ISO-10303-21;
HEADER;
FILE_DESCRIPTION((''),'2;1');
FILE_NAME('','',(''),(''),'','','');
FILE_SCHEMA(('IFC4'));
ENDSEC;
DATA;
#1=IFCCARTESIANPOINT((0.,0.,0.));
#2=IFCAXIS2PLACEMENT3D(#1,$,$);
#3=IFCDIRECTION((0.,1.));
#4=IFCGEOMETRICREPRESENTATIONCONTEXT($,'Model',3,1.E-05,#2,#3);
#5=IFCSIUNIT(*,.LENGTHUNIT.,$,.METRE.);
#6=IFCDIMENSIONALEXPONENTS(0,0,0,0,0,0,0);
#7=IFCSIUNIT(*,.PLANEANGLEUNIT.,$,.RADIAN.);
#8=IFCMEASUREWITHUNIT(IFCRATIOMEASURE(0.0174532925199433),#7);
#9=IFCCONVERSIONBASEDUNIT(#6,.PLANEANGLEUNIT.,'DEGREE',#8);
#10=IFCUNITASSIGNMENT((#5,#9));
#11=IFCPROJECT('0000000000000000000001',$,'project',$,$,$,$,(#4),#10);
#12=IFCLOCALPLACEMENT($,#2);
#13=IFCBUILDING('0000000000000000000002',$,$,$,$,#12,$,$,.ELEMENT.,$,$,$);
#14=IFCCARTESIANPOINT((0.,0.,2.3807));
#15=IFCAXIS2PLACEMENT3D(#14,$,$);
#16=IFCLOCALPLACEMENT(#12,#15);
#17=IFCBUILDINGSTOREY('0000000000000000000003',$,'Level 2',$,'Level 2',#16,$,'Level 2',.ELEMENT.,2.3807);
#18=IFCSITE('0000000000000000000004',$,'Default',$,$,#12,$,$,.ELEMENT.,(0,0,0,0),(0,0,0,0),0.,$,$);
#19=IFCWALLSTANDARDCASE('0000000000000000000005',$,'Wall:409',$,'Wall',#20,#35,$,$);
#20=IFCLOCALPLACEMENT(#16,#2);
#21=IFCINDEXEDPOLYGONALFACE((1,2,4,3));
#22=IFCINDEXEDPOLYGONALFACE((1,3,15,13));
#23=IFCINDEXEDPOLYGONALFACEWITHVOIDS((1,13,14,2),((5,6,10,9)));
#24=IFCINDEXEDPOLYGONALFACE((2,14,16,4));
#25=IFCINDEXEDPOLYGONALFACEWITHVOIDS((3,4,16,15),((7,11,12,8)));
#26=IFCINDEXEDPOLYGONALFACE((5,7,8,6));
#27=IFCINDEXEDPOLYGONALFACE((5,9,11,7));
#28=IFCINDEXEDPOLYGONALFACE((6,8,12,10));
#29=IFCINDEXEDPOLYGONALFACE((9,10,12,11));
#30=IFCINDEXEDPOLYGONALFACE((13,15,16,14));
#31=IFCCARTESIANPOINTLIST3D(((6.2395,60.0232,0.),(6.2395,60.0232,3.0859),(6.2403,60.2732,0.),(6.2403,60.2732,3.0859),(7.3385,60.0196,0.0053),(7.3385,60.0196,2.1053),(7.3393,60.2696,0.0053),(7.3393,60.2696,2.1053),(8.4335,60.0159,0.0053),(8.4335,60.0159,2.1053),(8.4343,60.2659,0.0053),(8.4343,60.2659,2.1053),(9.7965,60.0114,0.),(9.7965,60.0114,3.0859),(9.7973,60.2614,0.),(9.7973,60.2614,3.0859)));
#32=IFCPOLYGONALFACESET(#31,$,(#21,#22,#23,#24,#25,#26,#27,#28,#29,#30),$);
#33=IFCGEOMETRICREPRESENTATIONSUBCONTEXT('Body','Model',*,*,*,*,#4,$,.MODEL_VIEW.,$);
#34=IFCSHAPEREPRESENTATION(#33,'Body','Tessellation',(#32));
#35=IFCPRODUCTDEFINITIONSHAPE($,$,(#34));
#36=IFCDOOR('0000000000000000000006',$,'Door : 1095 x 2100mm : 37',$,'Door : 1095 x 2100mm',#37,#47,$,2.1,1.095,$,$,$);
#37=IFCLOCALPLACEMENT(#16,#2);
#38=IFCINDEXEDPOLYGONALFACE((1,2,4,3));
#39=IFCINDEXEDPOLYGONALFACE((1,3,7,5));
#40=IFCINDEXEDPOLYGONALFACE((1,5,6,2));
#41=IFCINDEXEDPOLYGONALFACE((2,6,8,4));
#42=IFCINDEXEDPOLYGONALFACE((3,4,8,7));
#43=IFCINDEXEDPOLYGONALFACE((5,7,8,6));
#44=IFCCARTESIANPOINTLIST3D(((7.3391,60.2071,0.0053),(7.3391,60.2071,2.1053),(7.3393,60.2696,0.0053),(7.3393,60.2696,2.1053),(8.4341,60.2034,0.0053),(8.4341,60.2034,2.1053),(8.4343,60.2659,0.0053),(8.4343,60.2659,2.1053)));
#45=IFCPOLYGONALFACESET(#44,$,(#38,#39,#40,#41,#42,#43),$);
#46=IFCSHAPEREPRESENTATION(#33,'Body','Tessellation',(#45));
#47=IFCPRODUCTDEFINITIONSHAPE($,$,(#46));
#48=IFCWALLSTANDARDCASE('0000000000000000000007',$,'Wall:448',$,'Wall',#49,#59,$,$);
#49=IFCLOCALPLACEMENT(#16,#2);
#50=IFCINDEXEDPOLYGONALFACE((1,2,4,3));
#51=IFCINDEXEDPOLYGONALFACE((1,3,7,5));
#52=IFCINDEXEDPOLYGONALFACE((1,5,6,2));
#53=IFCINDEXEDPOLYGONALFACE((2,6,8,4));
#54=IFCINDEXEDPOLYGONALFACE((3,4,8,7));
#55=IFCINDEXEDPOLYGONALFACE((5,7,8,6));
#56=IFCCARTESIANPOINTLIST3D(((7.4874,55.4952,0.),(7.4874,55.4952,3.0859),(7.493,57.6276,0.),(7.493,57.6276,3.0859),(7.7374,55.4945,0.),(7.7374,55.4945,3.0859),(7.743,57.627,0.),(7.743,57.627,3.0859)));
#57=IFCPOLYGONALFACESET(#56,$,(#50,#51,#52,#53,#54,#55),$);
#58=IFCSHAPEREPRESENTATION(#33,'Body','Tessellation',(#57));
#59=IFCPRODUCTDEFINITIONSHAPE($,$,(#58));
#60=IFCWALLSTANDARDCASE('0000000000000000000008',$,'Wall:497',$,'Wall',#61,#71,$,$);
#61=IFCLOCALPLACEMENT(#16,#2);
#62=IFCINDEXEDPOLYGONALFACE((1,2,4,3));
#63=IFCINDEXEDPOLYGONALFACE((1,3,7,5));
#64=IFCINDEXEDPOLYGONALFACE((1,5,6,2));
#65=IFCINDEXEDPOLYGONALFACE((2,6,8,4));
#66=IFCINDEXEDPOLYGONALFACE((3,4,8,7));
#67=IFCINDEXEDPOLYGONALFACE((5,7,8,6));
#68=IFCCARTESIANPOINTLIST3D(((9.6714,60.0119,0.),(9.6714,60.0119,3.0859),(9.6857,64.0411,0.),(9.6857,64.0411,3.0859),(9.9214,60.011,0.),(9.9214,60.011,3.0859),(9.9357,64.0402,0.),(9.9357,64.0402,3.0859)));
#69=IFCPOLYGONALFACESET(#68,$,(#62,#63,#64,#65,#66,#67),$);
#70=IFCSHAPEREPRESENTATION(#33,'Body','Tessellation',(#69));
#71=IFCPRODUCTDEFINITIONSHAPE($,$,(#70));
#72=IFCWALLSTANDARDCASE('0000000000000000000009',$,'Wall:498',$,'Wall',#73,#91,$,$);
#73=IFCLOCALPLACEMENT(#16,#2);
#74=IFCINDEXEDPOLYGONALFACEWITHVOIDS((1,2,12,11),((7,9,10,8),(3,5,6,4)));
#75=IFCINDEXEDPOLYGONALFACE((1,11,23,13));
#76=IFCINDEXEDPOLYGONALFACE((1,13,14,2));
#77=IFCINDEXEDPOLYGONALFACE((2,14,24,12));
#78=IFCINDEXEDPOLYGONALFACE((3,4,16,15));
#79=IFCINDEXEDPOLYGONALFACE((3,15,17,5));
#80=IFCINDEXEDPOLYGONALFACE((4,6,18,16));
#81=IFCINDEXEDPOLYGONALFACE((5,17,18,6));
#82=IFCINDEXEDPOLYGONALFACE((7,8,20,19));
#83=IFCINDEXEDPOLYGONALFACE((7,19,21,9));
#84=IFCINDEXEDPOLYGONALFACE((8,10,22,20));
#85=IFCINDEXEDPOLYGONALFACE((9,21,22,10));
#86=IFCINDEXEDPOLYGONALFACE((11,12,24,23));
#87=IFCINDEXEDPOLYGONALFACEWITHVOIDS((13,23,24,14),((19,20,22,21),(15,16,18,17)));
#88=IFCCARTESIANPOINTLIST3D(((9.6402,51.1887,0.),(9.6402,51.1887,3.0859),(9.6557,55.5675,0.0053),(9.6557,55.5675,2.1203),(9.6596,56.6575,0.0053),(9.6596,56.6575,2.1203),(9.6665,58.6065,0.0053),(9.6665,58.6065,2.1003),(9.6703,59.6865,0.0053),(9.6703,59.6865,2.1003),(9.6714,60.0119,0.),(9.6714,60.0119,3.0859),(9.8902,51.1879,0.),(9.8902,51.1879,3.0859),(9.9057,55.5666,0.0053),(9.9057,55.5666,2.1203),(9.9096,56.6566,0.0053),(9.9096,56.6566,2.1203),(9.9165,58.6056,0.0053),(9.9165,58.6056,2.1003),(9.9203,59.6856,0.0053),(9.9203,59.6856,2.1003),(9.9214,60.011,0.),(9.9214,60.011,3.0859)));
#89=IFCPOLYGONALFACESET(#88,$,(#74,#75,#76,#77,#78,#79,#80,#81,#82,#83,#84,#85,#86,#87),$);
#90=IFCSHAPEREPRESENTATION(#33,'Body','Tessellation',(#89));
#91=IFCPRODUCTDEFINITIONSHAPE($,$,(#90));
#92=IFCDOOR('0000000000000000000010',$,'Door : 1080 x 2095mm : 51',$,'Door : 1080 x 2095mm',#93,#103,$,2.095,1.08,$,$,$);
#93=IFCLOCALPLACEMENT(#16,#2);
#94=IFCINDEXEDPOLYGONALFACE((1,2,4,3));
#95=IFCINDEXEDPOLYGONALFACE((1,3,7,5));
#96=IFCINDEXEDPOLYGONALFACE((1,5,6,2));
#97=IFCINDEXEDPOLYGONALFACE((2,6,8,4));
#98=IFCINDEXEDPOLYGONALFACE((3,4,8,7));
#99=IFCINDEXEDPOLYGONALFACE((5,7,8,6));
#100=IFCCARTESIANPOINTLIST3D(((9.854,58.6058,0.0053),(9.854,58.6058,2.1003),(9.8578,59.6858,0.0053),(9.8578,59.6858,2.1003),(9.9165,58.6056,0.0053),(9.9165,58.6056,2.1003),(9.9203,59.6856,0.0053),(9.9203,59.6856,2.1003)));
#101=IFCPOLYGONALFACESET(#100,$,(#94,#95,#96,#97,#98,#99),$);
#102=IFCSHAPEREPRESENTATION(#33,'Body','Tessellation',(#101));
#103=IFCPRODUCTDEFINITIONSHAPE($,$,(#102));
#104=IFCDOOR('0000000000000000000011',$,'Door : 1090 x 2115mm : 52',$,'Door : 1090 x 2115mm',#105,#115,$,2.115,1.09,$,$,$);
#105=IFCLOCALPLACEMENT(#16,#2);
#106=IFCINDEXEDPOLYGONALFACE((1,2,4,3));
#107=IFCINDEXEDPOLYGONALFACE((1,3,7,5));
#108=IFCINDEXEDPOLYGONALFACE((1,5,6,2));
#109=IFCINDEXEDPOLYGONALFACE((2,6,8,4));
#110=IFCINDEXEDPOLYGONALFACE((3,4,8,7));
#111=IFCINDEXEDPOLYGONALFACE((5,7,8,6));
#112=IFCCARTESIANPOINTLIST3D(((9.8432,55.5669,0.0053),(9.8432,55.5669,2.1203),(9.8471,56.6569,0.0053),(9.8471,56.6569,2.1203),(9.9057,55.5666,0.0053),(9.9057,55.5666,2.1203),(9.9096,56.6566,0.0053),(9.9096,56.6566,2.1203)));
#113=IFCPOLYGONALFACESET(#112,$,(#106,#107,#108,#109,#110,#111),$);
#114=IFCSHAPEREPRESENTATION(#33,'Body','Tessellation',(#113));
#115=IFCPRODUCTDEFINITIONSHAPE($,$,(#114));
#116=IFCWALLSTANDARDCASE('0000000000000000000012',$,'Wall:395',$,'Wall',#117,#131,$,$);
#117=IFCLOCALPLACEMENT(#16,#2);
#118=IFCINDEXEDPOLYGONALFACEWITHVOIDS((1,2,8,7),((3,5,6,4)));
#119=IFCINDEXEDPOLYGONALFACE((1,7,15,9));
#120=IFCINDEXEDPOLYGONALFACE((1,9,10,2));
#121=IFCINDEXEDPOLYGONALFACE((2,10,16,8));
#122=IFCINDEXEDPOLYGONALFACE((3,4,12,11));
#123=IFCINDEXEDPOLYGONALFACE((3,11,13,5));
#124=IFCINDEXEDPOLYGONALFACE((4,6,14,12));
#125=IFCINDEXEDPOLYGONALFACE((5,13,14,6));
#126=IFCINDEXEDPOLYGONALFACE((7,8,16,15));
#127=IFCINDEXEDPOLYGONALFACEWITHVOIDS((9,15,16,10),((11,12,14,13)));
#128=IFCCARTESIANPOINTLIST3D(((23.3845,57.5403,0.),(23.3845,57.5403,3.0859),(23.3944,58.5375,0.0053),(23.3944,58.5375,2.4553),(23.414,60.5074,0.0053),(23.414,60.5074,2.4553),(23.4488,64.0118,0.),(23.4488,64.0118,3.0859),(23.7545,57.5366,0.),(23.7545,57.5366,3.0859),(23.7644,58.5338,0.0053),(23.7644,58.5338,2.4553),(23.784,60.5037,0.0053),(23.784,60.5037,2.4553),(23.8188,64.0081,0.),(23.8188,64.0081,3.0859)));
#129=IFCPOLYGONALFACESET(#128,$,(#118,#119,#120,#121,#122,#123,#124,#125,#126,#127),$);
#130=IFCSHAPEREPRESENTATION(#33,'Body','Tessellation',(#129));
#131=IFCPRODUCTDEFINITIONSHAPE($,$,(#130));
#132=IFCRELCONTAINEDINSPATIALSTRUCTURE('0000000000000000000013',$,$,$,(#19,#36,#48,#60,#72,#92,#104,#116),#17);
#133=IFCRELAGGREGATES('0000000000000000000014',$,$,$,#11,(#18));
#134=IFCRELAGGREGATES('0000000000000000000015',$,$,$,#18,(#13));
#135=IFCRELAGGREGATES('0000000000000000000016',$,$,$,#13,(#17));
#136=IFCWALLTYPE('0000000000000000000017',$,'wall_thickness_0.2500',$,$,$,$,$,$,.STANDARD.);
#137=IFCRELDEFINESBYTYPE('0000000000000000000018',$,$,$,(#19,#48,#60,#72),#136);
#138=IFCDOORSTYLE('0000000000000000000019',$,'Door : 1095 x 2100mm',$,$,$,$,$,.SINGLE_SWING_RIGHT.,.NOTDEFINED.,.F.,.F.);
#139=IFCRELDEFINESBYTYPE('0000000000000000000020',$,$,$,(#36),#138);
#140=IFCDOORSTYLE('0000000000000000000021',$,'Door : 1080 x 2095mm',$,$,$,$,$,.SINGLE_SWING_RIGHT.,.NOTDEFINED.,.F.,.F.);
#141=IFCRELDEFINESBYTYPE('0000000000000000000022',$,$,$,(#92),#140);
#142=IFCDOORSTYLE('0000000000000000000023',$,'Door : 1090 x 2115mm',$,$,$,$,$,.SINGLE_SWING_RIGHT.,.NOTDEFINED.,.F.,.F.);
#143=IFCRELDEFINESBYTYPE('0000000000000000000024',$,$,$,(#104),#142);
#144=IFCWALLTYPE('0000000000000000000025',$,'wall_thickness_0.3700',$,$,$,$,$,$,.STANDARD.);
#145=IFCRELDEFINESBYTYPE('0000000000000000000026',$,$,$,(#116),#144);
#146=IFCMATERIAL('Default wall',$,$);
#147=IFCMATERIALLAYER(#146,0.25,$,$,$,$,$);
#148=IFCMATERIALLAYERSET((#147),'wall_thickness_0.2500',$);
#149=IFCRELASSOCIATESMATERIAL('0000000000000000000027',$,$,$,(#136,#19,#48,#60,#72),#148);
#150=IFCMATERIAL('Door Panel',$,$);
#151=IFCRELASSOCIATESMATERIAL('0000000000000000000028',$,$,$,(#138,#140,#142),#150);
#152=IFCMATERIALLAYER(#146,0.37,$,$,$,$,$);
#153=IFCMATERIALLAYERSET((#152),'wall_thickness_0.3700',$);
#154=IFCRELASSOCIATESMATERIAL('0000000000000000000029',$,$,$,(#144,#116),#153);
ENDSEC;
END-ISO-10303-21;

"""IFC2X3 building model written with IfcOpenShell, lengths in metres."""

from ifc_helpers import new_model, entity, si_unit, converted_unit, direction, frame, frame_2d, origin, origin_2d_with_axis, place, context, subcontext, project, spatial, polyline, rectangle, outline, extrude, source, transform, mapped, material, layer, layer_set, layer_usage, type_object, type_shapes, element, fill, save


model = new_model("IFC2X3")

# Units and contexts
model_context = context("Model", 3, precision=1e-05, world=origin(), true_north=direction((0.0, 1.0)))
body_context = subcontext(model_context, "Body", "Model", "MODEL_VIEW")
ifc_project = project(units=[si_unit("LENGTHUNIT", "METRE"), converted_unit("PLANEANGLEUNIT", "DEGREE", entity("IfcRatioMeasure", 0.0174532925199433), si_unit("PLANEANGLEUNIT", "RADIAN"), dimensions=[0, 0, 0, 0, 0, 0, 0])], contexts=[model_context])

# Site, building, storey
placement_1 = place(None, origin())
site = spatial("IfcSite", under=ifc_project, at=placement_1, Name="Default", CompositionType="ELEMENT", RefLatitude=(0, 0, 0, 0), RefLongitude=(0, 0, 0, 0), RefElevation=0.0)
building = spatial("IfcBuilding", under=site, at=placement_1, CompositionType="ELEMENT")
storey_placement = place(placement_1, frame((0.0, 0.0, 2.3807)))
storey = spatial("IfcBuildingStorey", under=building, at=storey_placement, Name="Level 2", ObjectType="Level 2", LongName="Level 2", CompositionType="ELEMENT", Elevation=2.3807)

# Shared definitions
ifc_material_1 = material(Name="Default wall")

# Shared definitions
ifc_layer_1 = layer(ifc_material_1, 0.25)
ifc_layer_set_1 = layer_set([ifc_layer_1], Name="wall_thickness_0.2500")
ifc_layer_usage_1 = layer_usage(ifc_layer_set_1, "AXIS2", "POSITIVE", -0.125)
wall_type_1 = type_object("IfcWallType", Name="wall_thickness_0.2500", PredefinedType="STANDARD", material=ifc_layer_set_1)

# Wall, opening, door
wall_1_placement = place(storey_placement, frame((6.2399, 60.1482, 0.0), z_axis=(0.0, 0.0, 1.0), x_axis=(0.999995, -0.003299, 0.0)))
wall_1 = element("IfcWallStandardCase", 1, at=wall_1_placement, inside=storey, type_object=wall_type_1, material=ifc_layer_usage_1, Name="Wall:409", ObjectType="Wall", context=body_context, shape_type="SweptSolid", body=[
    extrude(outline(polyline([(3.557, -0.125), (3.557, 0.125), (0.0, 0.125), (0.0, -0.125), (3.557, -0.125)])), origin(), (0.0, 0.0, 1.0), 3.0859),
])
opening_1_placement = place(wall_1_placement, frame((1.099, -0.125, 0.0053)))
opening_1 = element("IfcOpeningElement", 2, at=opening_1_placement, cuts=wall_1, ObjectType="Opening", context=body_context, shape_type="SweptSolid", body=[
    extrude(rectangle(XDim=1.095, YDim=2.1, at=frame_2d((1.05, 0.5475), x_axis=(0.0, 1.0))), frame((0.0, 0.0, 0.0), z_axis=(0.0, 1.0, 0.0), x_axis=(0.0, 0.0, 1.0)), (0.0, 0.0, 1.0), 0.25),
])
ifc_material_2 = material(Name="Door Panel")
door_style_1 = type_object("IfcDoorStyle", Name="Door : 1095 x 2100mm", ConstructionType="NOTDEFINED", OperationType="SINGLE_SWING_RIGHT", ParameterTakesPrecedence=False, Sizeable=False, material=ifc_material_2)
shared_shape_1 = source(origin(), body_context, "Body", "SweptSolid", [
    extrude(rectangle(XDim=0.0625, YDim=1.095, at=origin_2d_with_axis()), frame((0.5475, 0.2188, 0.0), z_axis=(0.0, 0.0, 1.0), x_axis=(0.0, 1.0, 0.0)), (0.0, 0.0, 1.0), 2.1),
])
type_shapes(door_style_1, [shared_shape_1])
door_1_placement = place(opening_1_placement, origin())
door_1 = element("IfcDoor", 3, at=door_1_placement, inside=storey, type_object=door_style_1, Name="Door : 1095 x 2100mm : 37", ObjectType="Door : 1095 x 2100mm", OverallHeight=2.1, OverallWidth=1.095, context=body_context, shape_type="MappedRepresentation", body=[
    mapped(shared_shape_1, transform((0.0, 0.0, 0.0), scale=1.0)),
])
fill(opening_1, door_1)

# Walls
wall_2_placement = place(storey_placement, frame((7.618, 57.6273, 0.0), z_axis=(0.0, 0.0, 1.0), x_axis=(-0.002626, -0.999997, 0.0)))
element("IfcWallStandardCase", 4, at=wall_2_placement, inside=storey, type_object=wall_type_1, material=ifc_layer_usage_1, Name="Wall:448", ObjectType="Wall", context=body_context, shape_type="SweptSolid", body=[
    extrude(outline(polyline([(2.1325, -0.125), (2.1325, 0.125), (0.0, 0.125), (0.0, -0.125), (2.1325, -0.125)])), origin(), (0.0, 0.0, 1.0), 3.0859),
])
wall_3_placement = place(storey_placement, frame((9.8107, 64.0407, 0.0), z_axis=(0.0, 0.0, 1.0), x_axis=(-0.003537, -0.999994, 0.0)))
element("IfcWallStandardCase", 5, at=wall_3_placement, inside=storey, type_object=wall_type_1, material=ifc_layer_usage_1, Name="Wall:497", ObjectType="Wall", context=body_context, shape_type="SweptSolid", body=[
    extrude(outline(polyline([(4.0293, -0.125), (4.0293, 0.125), (0.0, 0.125), (0.0, -0.125), (4.0293, -0.125)])), origin(), (0.0, 0.0, 1.0), 3.0859),
])

# Wall, openings, doors
wall_4_placement = place(storey_placement, frame((9.7964, 60.0114, 0.0), z_axis=(0.0, 0.0, 1.0), x_axis=(-0.003537, -0.999994, 0.0)))
wall_4 = element("IfcWallStandardCase", 6, at=wall_4_placement, inside=storey, type_object=wall_type_1, material=ifc_layer_usage_1, Name="Wall:498", ObjectType="Wall", context=body_context, shape_type="SweptSolid", body=[
    extrude(outline(polyline([(8.8232, -0.125), (8.8232, 0.125), (0.0, 0.125), (0.0, -0.125), (8.8232, -0.125)])), origin(), (0.0, 0.0, 1.0), 3.0859),
])
opening_2_placement = place(wall_4_placement, frame((0.3254, -0.125, 0.0053)))
opening_2 = element("IfcOpeningElement", 7, at=opening_2_placement, cuts=wall_4, ObjectType="Opening", context=body_context, shape_type="SweptSolid", body=[
    extrude(rectangle(XDim=1.08, YDim=2.095, at=frame_2d((1.0475, 0.54), x_axis=(0.0, 1.0))), frame((0.0, 0.0, 0.0), z_axis=(0.0, 1.0, 0.0), x_axis=(0.0, 0.0, 1.0)), (0.0, 0.0, 1.0), 0.25),
])
opening_3_placement = place(wall_4_placement, frame((3.3544, -0.125, 0.0053)))
opening_3 = element("IfcOpeningElement", 8, at=opening_3_placement, cuts=wall_4, ObjectType="Opening", context=body_context, shape_type="SweptSolid", body=[
    extrude(rectangle(XDim=1.09, YDim=2.115, at=frame_2d((1.0575, 0.545), x_axis=(0.0, 1.0))), frame((0.0, 0.0, 0.0), z_axis=(0.0, 1.0, 0.0), x_axis=(0.0, 0.0, 1.0)), (0.0, 0.0, 1.0), 0.25),
])
door_style_2 = type_object("IfcDoorStyle", Name="Door : 1080 x 2095mm", ConstructionType="NOTDEFINED", OperationType="SINGLE_SWING_RIGHT", ParameterTakesPrecedence=False, Sizeable=False, material=ifc_material_2)
shared_shape_2 = source(origin(), body_context, "Body", "SweptSolid", [
    extrude(rectangle(XDim=0.0625, YDim=1.08, at=origin_2d_with_axis()), frame((0.54, 0.2188, 0.0), z_axis=(0.0, 0.0, 1.0), x_axis=(0.0, 1.0, 0.0)), (0.0, 0.0, 1.0), 2.095),
])
type_shapes(door_style_2, [shared_shape_2])
door_2_placement = place(opening_2_placement, origin())
door_2 = element("IfcDoor", 9, at=door_2_placement, inside=storey, type_object=door_style_2, Name="Door : 1080 x 2095mm : 51", ObjectType="Door : 1080 x 2095mm", OverallHeight=2.095, OverallWidth=1.08, context=body_context, shape_type="MappedRepresentation", body=[
    mapped(shared_shape_2, transform((0.0, 0.0, 0.0), scale=1.0)),
])
fill(opening_2, door_2)
door_style_3 = type_object("IfcDoorStyle", Name="Door : 1090 x 2115mm", ConstructionType="NOTDEFINED", OperationType="SINGLE_SWING_RIGHT", ParameterTakesPrecedence=False, Sizeable=False, material=ifc_material_2)
shared_shape_3 = source(origin(), body_context, "Body", "SweptSolid", [
    extrude(rectangle(XDim=0.0625, YDim=1.09, at=origin_2d_with_axis()), frame((0.545, 0.2188, 0.0), z_axis=(0.0, 0.0, 1.0), x_axis=(0.0, 1.0, 0.0)), (0.0, 0.0, 1.0), 2.115),
])
type_shapes(door_style_3, [shared_shape_3])
door_3_placement = place(opening_3_placement, origin())
door_3 = element("IfcDoor", 10, at=door_3_placement, inside=storey, type_object=door_style_3, Name="Door : 1090 x 2115mm : 52", ObjectType="Door : 1090 x 2115mm", OverallHeight=2.115, OverallWidth=1.09, context=body_context, shape_type="MappedRepresentation", body=[
    mapped(shared_shape_3, transform((0.0, 0.0, 0.0), scale=1.0)),
])
fill(opening_3, door_3)

# Wall, opening
ifc_layer_2 = layer(ifc_material_1, 0.37)
ifc_layer_set_2 = layer_set([ifc_layer_2], Name="wall_thickness_0.3700")
ifc_layer_usage_2 = layer_usage(ifc_layer_set_2, "AXIS2", "POSITIVE", -0.185)
wall_type_2 = type_object("IfcWallType", Name="wall_thickness_0.3700", PredefinedType="STANDARD", material=ifc_layer_set_2)
wall_5_placement = place(storey_placement, frame((23.6338, 64.0099, 0.0), z_axis=(0.0, 0.0, 1.0), x_axis=(-0.009938, -0.999951, 0.0)))
wall_5 = element("IfcWallStandardCase", 11, at=wall_5_placement, inside=storey, type_object=wall_type_2, material=ifc_layer_usage_2, Name="Wall:395", ObjectType="Wall", context=body_context, shape_type="SweptSolid", body=[
    extrude(outline(polyline([(6.4718, -0.185), (6.4718, 0.185), (0.0, 0.185), (0.0, -0.185), (6.4718, -0.185)])), origin(), (0.0, 0.0, 1.0), 3.0859),
])
opening_4_placement = place(wall_5_placement, frame((3.5045, -0.185, 0.0053)))
element("IfcOpeningElement", 12, at=opening_4_placement, cuts=wall_5, ObjectType="Opening", context=body_context, shape_type="SweptSolid", body=[
    extrude(rectangle(XDim=1.97, YDim=2.45, at=frame_2d((1.225, 0.985), x_axis=(0.0, 1.0))), frame((0.0, 0.0, 0.0), z_axis=(0.0, 1.0, 0.0), x_axis=(0.0, 0.0, 1.0)), (0.0, 0.0, 1.0), 0.37),
])

save(model, "model.ifc")
